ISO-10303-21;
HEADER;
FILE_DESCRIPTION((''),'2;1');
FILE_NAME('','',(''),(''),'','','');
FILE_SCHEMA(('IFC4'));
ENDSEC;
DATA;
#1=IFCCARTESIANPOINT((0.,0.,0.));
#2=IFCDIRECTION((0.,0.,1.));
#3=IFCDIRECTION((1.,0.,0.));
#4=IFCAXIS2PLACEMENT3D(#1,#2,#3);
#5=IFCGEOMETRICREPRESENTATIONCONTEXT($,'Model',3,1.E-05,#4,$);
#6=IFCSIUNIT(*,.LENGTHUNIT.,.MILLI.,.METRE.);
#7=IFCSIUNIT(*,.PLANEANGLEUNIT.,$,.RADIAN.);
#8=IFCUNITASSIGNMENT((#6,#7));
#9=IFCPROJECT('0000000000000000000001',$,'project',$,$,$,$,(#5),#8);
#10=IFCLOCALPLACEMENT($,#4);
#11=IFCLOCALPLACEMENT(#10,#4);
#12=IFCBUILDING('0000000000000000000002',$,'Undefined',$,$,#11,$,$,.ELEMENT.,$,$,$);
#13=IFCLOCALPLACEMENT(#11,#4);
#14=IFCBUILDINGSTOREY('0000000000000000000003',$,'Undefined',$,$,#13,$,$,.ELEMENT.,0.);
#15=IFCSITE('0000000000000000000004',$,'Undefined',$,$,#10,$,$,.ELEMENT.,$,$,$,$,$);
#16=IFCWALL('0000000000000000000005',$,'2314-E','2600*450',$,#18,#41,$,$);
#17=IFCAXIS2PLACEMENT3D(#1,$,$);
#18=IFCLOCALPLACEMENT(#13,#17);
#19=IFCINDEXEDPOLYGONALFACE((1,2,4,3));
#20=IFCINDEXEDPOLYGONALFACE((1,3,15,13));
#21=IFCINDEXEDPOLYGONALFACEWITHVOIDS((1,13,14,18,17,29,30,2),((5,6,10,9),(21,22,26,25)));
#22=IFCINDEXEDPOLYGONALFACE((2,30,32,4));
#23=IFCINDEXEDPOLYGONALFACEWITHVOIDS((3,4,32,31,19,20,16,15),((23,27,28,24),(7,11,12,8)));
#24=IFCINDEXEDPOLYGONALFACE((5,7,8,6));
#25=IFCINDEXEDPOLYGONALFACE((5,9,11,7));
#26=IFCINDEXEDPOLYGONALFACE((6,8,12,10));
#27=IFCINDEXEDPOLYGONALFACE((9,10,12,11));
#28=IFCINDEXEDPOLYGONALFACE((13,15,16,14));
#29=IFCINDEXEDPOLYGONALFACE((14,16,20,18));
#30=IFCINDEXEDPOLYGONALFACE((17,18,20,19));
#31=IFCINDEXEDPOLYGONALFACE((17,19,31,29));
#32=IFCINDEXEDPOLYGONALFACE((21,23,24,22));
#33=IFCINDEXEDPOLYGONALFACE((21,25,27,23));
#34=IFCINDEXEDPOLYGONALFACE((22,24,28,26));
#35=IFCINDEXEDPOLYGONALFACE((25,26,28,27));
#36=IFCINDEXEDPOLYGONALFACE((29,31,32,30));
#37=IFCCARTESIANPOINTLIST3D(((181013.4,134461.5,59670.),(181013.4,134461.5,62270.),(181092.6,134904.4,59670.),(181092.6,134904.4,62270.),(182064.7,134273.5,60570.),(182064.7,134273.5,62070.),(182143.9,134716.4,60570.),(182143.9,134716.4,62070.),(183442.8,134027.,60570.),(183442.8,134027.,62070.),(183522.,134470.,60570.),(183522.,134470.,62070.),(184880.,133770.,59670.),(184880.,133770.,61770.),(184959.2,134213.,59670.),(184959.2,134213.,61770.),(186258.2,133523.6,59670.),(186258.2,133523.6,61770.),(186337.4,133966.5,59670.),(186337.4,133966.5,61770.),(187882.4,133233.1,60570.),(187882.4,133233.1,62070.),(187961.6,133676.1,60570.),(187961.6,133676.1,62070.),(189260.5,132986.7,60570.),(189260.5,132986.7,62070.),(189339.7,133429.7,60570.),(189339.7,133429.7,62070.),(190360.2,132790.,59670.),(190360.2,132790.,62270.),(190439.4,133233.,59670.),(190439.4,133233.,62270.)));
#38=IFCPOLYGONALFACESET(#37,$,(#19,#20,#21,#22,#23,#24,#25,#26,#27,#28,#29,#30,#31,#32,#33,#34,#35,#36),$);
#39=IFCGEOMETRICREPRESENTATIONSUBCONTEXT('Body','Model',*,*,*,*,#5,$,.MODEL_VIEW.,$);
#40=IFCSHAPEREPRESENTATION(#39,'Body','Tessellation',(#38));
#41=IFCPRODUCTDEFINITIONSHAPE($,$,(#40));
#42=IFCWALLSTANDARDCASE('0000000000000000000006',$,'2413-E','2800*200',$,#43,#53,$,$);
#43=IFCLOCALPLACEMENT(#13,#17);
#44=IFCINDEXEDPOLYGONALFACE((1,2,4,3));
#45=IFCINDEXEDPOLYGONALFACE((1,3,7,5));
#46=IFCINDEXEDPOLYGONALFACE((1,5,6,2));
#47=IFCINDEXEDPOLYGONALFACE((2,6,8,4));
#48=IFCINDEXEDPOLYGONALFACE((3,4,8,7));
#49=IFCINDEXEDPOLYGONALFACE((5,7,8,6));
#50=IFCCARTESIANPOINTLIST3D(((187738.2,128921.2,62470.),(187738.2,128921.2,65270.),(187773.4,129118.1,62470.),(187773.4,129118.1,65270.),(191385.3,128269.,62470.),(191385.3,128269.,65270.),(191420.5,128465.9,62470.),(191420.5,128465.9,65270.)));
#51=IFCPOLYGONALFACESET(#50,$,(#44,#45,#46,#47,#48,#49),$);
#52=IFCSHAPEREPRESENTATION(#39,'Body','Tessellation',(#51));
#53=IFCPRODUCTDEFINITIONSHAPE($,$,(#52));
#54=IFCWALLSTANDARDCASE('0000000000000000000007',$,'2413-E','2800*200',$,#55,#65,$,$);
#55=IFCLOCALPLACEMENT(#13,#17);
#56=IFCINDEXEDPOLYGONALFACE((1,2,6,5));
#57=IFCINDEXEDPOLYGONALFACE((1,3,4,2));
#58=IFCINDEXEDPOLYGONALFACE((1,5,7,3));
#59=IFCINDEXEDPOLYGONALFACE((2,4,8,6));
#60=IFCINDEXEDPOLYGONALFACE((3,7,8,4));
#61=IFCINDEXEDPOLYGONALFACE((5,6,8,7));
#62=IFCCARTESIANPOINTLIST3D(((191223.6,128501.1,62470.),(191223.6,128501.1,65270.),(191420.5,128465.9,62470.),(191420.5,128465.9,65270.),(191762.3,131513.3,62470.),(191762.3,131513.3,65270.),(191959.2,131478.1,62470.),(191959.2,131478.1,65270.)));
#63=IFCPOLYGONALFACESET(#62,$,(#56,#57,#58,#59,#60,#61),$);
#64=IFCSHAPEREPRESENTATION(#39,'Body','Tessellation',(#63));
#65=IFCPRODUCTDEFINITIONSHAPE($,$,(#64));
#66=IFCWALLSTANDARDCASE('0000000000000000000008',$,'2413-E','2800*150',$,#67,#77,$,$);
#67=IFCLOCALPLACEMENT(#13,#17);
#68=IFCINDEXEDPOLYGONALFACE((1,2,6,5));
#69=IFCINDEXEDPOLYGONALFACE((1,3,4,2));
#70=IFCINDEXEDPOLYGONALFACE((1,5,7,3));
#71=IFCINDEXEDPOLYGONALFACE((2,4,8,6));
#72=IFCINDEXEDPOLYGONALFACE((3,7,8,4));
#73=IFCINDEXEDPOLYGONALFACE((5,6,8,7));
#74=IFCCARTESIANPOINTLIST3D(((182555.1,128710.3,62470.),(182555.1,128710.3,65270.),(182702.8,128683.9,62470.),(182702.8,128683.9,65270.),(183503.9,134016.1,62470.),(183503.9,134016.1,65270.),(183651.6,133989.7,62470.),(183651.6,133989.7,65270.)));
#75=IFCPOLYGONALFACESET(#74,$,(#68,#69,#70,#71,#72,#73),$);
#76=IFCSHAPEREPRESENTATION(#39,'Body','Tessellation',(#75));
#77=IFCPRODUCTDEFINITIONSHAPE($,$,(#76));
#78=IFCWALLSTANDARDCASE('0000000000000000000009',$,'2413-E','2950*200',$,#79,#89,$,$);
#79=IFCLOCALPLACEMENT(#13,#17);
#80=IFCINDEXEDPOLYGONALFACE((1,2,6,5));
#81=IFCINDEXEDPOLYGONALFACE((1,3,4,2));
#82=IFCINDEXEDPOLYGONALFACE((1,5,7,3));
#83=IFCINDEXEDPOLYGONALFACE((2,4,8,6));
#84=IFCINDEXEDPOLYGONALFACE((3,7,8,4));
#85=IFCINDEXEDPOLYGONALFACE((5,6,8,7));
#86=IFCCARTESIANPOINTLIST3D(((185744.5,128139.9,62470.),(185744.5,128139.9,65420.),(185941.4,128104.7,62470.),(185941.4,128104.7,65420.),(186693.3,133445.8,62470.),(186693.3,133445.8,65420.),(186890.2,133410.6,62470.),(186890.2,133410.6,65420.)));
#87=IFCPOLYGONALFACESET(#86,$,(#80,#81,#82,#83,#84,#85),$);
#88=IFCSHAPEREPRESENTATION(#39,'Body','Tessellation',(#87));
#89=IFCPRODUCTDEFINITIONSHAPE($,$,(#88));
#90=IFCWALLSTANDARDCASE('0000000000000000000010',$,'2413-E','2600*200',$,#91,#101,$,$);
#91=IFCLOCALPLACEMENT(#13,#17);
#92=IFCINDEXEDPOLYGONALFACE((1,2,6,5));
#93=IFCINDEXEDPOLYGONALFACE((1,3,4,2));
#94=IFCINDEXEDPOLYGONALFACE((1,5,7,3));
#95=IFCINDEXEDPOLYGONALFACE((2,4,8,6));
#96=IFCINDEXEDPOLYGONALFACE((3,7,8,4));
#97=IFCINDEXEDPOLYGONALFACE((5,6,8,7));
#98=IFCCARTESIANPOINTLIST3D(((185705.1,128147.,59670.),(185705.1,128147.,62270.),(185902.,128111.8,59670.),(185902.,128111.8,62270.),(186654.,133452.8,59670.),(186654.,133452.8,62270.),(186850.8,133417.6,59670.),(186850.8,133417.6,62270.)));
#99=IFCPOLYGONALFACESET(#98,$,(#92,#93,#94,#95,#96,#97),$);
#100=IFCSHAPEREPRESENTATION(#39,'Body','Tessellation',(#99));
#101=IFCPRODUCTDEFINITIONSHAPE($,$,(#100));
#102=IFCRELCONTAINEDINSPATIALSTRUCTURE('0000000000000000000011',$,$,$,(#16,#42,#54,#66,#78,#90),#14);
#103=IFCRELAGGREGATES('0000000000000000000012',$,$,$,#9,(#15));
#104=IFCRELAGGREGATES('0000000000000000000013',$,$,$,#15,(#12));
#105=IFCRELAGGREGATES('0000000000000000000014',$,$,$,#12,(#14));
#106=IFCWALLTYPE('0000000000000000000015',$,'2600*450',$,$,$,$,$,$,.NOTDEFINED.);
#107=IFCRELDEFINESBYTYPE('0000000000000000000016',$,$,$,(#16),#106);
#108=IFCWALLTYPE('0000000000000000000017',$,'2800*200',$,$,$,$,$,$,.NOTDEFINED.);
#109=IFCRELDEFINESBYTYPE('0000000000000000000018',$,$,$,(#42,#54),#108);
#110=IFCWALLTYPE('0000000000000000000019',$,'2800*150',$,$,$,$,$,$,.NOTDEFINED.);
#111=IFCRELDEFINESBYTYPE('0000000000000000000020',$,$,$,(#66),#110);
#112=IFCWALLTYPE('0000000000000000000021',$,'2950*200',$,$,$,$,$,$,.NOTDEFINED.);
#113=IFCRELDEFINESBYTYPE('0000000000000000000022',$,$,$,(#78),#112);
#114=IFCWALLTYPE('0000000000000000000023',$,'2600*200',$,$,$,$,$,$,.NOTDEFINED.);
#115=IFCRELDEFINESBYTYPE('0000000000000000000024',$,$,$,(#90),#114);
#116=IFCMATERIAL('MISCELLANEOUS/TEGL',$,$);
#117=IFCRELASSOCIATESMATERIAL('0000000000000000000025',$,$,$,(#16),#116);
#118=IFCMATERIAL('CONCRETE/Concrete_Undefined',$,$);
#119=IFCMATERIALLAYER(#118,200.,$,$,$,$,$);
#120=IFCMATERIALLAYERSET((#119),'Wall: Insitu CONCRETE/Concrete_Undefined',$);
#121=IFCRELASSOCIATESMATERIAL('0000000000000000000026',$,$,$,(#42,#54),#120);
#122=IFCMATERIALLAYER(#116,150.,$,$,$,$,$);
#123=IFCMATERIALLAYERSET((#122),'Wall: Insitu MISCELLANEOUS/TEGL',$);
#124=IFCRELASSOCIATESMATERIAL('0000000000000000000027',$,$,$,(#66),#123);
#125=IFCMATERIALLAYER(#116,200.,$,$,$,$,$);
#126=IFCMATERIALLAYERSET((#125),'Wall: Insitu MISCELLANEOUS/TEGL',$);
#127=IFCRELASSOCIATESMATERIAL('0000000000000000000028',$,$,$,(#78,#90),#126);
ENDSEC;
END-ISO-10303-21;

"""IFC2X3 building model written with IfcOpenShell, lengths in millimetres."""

from ifc_helpers import new_model, si_unit, frame, frame_2d, origin_with_axes, place, context, subcontext, project, spatial, rectangle, extrude, boolean, material, layer, layer_set, layer_usage, type_object, element, save


model = new_model("IFC2X3")

# Units and contexts
model_context = context("Model", 3, precision=1e-05, world=origin_with_axes())
body_context = subcontext(model_context, "Body", "Model", "MODEL_VIEW")
ifc_project = project(units=[si_unit("LENGTHUNIT", "METRE", prefix="MILLI"), si_unit("PLANEANGLEUNIT", "RADIAN")], contexts=[model_context])

# Site, building, storey
site_placement = place(None, origin_with_axes())
site = spatial("IfcSite", under=ifc_project, at=site_placement, Name="Undefined", CompositionType="ELEMENT")
building_placement = place(site_placement, origin_with_axes())
building = spatial("IfcBuilding", under=site, at=building_placement, Name="Undefined", CompositionType="ELEMENT")
storey_placement = place(building_placement, origin_with_axes())
storey = spatial("IfcBuildingStorey", under=building, at=storey_placement, Name="Undefined", CompositionType="ELEMENT", Elevation=0.0)

# Walls
ifc_material_1 = material(Name="MISCELLANEOUS/TEGL")
wall_type_1 = type_object("IfcWallType", Name="2600*450", PredefinedType="NOTDEFINED")
wall_1_placement = place(storey_placement, frame((181053.0, 134682.9, 59670.0), z_axis=(0.0, 0.0, 1.0), x_axis=(0.984385, -0.176032, 0.0)))
element("IfcWall", 1, at=wall_1_placement, inside=storey, type_object=wall_type_1, material=ifc_material_1, Name="2314-E", Description="2600*450", context=body_context, shape_type="CSG", body=[
    boolean("DIFFERENCE", boolean("DIFFERENCE", boolean("DIFFERENCE", extrude(rectangle(XDim=9495.0, YDim=450.0, at=frame_2d((0.0, 4747.5), x_axis=(0.0, -1.0))), frame((0.0, 0.0, 0.0), z_axis=(0.0, 0.0, 1.0), x_axis=(0.0, -1.0, 0.0)), (0.0, 0.0, 1.0), 2600.0), extrude(rectangle(XDim=1400.0, YDim=450.0, at=frame_2d((0.0, 700.0), x_axis=(0.0, -1.0))), frame((1067.9, 0.0, 900.0), z_axis=(0.0, 0.0, 1.0), x_axis=(0.0, -1.0, 0.0)), (0.0, 0.0, 1.0), 1500.0)), extrude(rectangle(XDim=1400.0, YDim=450.0, at=frame_2d((0.0, 700.0), x_axis=(0.0, -1.0))), frame((3927.9, 0.0, 0.0), z_axis=(0.0, 0.0, 1.0), x_axis=(0.0, -1.0, 0.0)), (0.0, 0.0, 1.0), 2100.0)), extrude(rectangle(XDim=1400.0, YDim=450.0, at=frame_2d((0.0, 700.0), x_axis=(0.0, -1.0))), frame((6977.9, 0.0, 900.0), z_axis=(0.0, 0.0, 1.0), x_axis=(0.0, -1.0, 0.0)), (0.0, 0.0, 1.0), 1500.0)),
])
ifc_material_2 = material(Name="CONCRETE/Concrete_Undefined")
ifc_layer_1 = layer(ifc_material_2, 200.0)
ifc_layer_set_1 = layer_set([ifc_layer_1], Name="Wall: Insitu CONCRETE/Concrete_Undefined")
ifc_layer_usage_1 = layer_usage(ifc_layer_set_1, "AXIS2", "POSITIVE", -100.0)
wall_type_2 = type_object("IfcWallType", Name="2800*200", PredefinedType="NOTDEFINED")
wall_2_placement = place(storey_placement, frame((187755.8, 129019.6, 62470.0), z_axis=(0.0, 0.0, 1.0), x_axis=(0.984385, -0.176032, 0.0)))
element("IfcWallStandardCase", 2, at=wall_2_placement, inside=storey, type_object=wall_type_2, material=ifc_layer_usage_1, Name="2413-E", Description="2800*200", context=body_context, shape_type="SweptSolid", body=[
    extrude(rectangle(XDim=3705.0, YDim=200.0, at=frame_2d((0.0, 1852.5), x_axis=(0.0, -1.0))), frame((0.0, 0.0, 0.0), z_axis=(0.0, 0.0, 1.0), x_axis=(0.0, -1.0, 0.0)), (0.0, 0.0, 1.0), 2800.0),
])
ifc_layer_usage_2 = layer_usage(ifc_layer_set_1, "AXIS2", "POSITIVE", -100.0)
wall_3_placement = place(storey_placement, frame((191860.7, 131495.7, 62470.0), z_axis=(0.0, 0.0, 1.0), x_axis=(-0.176033, -0.984384, 0.0)))
element("IfcWallStandardCase", 3, at=wall_3_placement, inside=storey, type_object=wall_type_2, material=ifc_layer_usage_2, Name="2413-E", Description="2800*200", context=body_context, shape_type="SweptSolid", body=[
    extrude(rectangle(XDim=3060.0, YDim=200.0, at=frame_2d((0.0, 1530.0), x_axis=(0.0, -1.0))), frame((0.0, 0.0, 0.0), z_axis=(0.0, 0.0, 1.0), x_axis=(0.0, -1.0, 0.0)), (0.0, 0.0, 1.0), 2800.0),
])
ifc_layer_2 = layer(ifc_material_1, 150.0)
ifc_layer_set_2 = layer_set([ifc_layer_2], Name="Wall: Insitu MISCELLANEOUS/TEGL")
ifc_layer_usage_3 = layer_usage(ifc_layer_set_2, "AXIS2", "POSITIVE", -75.0)
wall_type_3 = type_object("IfcWallType", Name="2800*150", PredefinedType="NOTDEFINED")
wall_4_placement = place(storey_placement, frame((182628.9, 128697.1, 62470.0), z_axis=(0.0, 0.0, 1.0), x_axis=(0.176032, 0.984385, 0.0)))
element("IfcWallStandardCase", 4, at=wall_4_placement, inside=storey, type_object=wall_type_3, material=ifc_layer_usage_3, Name="2413-E", Description="2800*150", context=body_context, shape_type="SweptSolid", body=[
    extrude(rectangle(XDim=5390.0, YDim=150.0, at=frame_2d((0.0, 2695.0), x_axis=(0.0, -1.0))), frame((0.0, 0.0, 0.0), z_axis=(0.0, 0.0, 1.0), x_axis=(0.0, -1.0, 0.0)), (0.0, 0.0, 1.0), 2800.0),
])
ifc_layer_3 = layer(ifc_material_1, 200.0)
ifc_layer_set_3 = layer_set([ifc_layer_3], Name="Wall: Insitu MISCELLANEOUS/TEGL")
ifc_layer_usage_4 = layer_usage(ifc_layer_set_3, "AXIS2", "POSITIVE", -100.0)
wall_type_4 = type_object("IfcWallType", Name="2950*200", PredefinedType="NOTDEFINED")
wall_5_placement = place(storey_placement, frame((186791.8, 133428.2, 62470.0), z_axis=(0.0, 0.0, 1.0), x_axis=(-0.176033, -0.984384, 0.0)))
element("IfcWallStandardCase", 5, at=wall_5_placement, inside=storey, type_object=wall_type_4, material=ifc_layer_usage_4, Name="2413-E", Description="2950*200", context=body_context, shape_type="SweptSolid", body=[
    extrude(rectangle(XDim=5390.0, YDim=200.0, at=frame_2d((0.0, 2695.0), x_axis=(0.0, -1.0))), frame((0.0, 0.0, 0.0), z_axis=(0.0, 0.0, 1.0), x_axis=(0.0, -1.0, 0.0)), (0.0, 0.0, 1.0), 2950.0),
])
ifc_layer_usage_5 = layer_usage(ifc_layer_set_3, "AXIS2", "POSITIVE", -100.0)
wall_type_5 = type_object("IfcWallType", Name="2600*200", PredefinedType="NOTDEFINED")
wall_6_placement = place(storey_placement, frame((186752.4, 133435.2, 59670.0), z_axis=(0.0, 0.0, 1.0), x_axis=(-0.176033, -0.984384, 0.0)))
element("IfcWallStandardCase", 6, at=wall_6_placement, inside=storey, type_object=wall_type_5, material=ifc_layer_usage_5, Name="2413-E", Description="2600*200", context=body_context, shape_type="SweptSolid", body=[
    extrude(rectangle(XDim=5390.0, YDim=200.0, at=frame_2d((0.0, 2695.0), x_axis=(0.0, -1.0))), frame((0.0, 0.0, 0.0), z_axis=(0.0, 0.0, 1.0), x_axis=(0.0, -1.0, 0.0)), (0.0, 0.0, 1.0), 2600.0),
])

save(model, "model.ifc")
